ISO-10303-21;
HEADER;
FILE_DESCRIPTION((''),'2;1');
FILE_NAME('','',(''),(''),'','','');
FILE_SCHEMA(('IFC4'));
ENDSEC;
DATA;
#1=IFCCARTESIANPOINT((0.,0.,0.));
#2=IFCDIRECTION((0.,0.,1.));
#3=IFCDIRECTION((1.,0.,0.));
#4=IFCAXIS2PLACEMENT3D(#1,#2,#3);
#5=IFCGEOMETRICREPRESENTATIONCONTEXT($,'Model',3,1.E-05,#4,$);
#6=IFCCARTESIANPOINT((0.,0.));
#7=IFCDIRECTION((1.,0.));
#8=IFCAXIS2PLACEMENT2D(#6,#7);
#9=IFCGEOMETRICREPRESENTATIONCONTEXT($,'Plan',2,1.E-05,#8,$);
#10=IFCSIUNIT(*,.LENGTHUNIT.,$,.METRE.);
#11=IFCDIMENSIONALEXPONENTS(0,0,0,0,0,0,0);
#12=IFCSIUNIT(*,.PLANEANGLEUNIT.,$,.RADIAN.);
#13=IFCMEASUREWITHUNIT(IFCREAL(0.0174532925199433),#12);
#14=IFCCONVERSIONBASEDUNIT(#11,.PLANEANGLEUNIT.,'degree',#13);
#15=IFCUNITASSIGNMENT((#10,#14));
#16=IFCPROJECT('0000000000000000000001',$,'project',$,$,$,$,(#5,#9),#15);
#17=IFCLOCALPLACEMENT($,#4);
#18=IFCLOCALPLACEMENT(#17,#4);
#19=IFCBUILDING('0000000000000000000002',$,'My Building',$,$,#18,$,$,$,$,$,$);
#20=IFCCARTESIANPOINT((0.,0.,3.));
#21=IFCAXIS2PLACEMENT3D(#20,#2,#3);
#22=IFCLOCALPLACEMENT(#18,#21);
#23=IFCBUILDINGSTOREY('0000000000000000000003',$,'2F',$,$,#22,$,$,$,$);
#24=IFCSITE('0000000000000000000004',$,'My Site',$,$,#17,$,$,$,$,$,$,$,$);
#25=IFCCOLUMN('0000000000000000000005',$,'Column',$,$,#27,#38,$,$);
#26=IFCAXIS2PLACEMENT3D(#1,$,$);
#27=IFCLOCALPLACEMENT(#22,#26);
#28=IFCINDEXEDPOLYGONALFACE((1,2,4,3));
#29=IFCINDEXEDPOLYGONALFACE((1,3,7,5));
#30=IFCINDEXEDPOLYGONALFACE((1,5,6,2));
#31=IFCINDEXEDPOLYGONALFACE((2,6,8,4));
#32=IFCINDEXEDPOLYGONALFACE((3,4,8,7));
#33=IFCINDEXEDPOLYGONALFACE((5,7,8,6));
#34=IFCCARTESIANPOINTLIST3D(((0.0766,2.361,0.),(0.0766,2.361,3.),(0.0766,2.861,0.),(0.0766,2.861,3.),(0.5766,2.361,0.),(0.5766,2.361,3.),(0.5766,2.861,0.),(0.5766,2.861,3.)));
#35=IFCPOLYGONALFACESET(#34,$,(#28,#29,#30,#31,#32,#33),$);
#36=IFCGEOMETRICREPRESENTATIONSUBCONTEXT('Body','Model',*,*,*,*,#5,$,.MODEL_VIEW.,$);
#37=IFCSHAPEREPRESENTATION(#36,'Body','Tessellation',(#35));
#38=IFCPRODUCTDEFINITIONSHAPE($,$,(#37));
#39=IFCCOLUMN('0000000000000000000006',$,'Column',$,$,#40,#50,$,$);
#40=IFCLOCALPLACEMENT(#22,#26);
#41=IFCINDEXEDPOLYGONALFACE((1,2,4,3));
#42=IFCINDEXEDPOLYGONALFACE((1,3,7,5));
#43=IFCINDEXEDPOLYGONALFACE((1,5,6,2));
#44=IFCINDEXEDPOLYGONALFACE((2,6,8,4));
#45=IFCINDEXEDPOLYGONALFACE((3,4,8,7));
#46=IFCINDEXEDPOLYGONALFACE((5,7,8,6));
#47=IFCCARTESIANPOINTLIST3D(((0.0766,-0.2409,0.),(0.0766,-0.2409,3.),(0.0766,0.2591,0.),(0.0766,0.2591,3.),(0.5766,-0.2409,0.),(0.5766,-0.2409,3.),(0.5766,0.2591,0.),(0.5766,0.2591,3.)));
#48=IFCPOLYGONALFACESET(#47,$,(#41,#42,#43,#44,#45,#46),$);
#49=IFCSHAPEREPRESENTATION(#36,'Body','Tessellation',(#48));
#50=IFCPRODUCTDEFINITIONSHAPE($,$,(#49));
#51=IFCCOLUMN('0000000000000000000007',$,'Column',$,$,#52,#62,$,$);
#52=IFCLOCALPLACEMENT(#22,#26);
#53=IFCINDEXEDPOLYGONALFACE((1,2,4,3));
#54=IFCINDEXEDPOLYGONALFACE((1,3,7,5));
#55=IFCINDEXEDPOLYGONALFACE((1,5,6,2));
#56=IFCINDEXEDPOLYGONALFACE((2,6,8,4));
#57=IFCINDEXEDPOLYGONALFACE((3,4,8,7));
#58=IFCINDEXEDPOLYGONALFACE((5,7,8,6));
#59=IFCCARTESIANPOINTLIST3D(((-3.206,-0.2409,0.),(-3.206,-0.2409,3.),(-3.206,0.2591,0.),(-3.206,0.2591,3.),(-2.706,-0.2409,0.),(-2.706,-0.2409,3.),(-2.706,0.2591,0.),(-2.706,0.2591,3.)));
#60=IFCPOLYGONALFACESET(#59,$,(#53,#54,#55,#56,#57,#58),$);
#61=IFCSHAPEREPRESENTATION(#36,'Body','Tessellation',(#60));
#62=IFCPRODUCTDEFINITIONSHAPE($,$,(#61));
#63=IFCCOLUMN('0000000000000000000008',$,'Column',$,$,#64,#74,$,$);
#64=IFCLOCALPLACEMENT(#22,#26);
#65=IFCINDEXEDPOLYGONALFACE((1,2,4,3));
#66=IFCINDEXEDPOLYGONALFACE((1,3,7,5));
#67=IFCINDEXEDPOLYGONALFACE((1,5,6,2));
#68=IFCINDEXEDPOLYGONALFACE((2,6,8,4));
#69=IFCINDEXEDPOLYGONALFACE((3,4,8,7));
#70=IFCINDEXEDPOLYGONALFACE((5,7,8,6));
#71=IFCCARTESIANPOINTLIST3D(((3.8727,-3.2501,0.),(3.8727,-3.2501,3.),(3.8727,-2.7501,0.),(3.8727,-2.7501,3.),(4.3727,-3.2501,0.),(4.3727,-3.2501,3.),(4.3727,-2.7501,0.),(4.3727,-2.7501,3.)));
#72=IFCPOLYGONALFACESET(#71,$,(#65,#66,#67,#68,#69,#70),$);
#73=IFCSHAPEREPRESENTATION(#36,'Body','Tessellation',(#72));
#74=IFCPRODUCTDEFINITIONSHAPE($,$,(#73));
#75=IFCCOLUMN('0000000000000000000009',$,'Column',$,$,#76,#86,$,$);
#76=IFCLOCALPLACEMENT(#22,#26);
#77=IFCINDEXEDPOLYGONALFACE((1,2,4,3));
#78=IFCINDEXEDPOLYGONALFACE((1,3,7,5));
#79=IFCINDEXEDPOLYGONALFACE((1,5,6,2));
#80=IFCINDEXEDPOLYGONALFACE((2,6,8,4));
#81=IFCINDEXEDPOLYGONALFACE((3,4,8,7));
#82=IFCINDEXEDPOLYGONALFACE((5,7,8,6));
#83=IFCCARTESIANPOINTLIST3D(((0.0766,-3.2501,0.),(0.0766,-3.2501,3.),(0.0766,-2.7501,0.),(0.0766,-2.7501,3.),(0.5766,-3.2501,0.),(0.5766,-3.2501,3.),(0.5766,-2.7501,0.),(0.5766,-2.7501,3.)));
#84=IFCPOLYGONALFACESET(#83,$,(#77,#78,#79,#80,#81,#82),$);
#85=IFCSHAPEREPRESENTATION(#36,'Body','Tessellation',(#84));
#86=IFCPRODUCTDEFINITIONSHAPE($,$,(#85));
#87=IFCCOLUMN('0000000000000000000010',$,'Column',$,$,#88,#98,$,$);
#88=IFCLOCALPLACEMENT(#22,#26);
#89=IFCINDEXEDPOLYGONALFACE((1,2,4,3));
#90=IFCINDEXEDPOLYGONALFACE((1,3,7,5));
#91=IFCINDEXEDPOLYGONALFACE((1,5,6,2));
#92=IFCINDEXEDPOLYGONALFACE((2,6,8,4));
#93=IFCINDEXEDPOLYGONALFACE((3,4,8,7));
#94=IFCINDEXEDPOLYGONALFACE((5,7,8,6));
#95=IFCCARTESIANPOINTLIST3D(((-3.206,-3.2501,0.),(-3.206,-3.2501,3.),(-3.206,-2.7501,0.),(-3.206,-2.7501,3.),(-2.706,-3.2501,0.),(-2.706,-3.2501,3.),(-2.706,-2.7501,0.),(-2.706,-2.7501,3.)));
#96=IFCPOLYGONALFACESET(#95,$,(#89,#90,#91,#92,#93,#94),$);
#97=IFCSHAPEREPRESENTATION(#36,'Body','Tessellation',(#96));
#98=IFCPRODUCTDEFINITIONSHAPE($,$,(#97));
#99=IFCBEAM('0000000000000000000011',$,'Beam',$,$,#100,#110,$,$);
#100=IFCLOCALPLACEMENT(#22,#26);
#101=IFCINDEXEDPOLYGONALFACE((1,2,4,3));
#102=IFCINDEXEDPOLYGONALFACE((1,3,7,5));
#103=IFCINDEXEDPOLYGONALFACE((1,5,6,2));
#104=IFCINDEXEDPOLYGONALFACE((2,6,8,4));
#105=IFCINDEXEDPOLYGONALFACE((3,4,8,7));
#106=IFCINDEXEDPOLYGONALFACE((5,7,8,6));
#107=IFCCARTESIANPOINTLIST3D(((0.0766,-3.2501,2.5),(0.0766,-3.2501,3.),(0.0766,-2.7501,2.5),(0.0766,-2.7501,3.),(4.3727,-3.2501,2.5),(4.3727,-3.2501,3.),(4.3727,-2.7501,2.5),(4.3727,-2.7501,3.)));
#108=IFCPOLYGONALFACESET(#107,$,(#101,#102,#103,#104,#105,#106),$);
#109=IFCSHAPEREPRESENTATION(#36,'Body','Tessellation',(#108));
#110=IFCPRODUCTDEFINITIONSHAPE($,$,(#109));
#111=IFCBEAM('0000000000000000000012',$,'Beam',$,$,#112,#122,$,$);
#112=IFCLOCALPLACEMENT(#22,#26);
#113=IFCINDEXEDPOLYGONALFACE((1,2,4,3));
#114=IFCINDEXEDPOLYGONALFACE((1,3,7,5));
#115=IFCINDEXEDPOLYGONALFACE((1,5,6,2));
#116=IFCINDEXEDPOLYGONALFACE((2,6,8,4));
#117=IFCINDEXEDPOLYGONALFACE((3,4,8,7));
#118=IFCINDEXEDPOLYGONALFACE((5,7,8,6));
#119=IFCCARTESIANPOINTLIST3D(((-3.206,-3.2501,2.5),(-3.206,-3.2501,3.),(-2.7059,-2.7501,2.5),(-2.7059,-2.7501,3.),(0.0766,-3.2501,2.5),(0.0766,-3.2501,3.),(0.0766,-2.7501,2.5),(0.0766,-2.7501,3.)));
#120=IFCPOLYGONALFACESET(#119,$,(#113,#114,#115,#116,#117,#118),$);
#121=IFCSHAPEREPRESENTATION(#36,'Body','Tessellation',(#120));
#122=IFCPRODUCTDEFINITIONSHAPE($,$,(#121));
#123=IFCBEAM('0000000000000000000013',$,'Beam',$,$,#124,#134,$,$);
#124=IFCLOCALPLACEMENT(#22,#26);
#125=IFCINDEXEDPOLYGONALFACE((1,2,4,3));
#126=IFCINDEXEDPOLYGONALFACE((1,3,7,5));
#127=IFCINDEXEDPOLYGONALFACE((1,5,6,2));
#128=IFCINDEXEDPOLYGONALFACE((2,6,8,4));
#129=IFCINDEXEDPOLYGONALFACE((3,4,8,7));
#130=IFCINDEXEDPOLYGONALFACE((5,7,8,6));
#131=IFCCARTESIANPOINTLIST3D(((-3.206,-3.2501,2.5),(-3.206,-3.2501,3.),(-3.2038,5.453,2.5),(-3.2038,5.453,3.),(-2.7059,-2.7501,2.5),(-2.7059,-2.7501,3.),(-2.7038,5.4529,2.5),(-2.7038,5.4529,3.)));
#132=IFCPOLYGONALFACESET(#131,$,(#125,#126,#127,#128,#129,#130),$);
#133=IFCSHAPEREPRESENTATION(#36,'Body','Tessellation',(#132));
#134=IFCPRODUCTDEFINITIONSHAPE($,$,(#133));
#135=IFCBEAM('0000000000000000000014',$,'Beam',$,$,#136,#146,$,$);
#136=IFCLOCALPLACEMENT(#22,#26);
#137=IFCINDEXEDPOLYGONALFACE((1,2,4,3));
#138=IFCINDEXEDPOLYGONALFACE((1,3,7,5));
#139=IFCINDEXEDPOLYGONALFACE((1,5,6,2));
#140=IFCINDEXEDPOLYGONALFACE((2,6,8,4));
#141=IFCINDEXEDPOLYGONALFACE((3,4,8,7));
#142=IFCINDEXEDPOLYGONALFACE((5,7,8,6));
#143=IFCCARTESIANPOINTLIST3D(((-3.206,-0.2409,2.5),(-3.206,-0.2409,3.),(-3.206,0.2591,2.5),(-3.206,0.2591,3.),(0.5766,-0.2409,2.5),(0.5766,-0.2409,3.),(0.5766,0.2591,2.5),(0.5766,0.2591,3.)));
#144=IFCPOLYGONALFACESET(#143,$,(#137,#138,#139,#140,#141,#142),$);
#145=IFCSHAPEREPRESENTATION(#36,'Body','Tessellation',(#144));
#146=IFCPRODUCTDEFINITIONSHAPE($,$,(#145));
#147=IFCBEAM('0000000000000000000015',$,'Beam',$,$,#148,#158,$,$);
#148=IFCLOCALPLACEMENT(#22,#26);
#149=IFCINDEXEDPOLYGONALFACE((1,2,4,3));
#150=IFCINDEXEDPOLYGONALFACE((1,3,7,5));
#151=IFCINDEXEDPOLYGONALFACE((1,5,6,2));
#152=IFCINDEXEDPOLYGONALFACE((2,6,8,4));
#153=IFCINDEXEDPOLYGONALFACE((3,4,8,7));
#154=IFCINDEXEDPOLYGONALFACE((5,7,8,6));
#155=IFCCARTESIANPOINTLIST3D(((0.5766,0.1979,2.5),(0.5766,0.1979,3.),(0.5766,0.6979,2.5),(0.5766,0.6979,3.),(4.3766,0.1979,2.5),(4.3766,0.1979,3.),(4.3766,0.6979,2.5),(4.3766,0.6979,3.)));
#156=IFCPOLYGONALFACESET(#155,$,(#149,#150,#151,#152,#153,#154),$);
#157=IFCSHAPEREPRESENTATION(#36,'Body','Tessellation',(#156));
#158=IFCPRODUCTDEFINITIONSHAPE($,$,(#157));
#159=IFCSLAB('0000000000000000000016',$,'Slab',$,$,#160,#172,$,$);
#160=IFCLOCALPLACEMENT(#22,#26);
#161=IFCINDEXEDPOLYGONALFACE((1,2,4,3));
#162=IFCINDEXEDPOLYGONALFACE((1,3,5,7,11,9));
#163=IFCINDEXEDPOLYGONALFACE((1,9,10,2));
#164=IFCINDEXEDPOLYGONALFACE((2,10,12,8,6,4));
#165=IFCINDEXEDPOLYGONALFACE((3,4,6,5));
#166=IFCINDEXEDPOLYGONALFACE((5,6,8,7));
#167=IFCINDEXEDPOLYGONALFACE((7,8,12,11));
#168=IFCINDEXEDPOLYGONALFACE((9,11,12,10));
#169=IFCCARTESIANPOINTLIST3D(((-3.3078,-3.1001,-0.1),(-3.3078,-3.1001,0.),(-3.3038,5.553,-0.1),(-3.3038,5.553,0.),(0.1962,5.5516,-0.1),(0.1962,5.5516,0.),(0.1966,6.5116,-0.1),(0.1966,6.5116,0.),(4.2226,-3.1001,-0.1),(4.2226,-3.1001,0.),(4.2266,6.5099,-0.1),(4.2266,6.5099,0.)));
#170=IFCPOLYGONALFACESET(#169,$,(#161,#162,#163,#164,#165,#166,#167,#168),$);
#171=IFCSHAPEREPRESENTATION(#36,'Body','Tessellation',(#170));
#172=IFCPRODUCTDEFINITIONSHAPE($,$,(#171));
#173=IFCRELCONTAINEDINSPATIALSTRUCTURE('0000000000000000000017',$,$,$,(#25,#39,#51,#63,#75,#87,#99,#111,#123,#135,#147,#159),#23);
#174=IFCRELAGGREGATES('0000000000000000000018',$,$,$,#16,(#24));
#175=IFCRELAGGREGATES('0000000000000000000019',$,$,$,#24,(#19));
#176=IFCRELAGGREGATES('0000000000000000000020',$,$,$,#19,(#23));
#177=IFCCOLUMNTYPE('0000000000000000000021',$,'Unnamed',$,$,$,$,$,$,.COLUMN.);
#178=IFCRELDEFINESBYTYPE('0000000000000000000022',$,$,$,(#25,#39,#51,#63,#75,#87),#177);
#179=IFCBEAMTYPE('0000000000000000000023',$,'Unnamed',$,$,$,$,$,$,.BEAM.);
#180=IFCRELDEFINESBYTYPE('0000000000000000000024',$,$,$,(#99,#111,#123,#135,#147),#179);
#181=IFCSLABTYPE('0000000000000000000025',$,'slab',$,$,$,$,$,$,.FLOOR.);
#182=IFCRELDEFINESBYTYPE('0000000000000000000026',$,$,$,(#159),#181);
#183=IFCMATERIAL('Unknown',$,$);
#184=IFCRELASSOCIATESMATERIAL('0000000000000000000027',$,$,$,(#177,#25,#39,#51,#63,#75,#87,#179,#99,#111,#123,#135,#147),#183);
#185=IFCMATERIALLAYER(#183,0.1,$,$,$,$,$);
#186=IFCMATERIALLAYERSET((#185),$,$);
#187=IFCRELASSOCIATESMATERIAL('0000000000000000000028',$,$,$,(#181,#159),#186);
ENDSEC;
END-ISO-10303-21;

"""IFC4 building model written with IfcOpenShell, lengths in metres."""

from ifc_helpers import new_model, entity, si_unit, converted_unit, frame, origin_with_axes, origin_2d_with_axis, place, context, subcontext, project, spatial, indexed_curve, rectangle, outline, extrude, clip, halfspace, material, layer, layer_set, layer_usage, material_profile, profile_set, profile_usage, type_object, element, save


model = new_model("IFC4")

# Units and contexts
model_context = context("Model", 3, precision=1e-05, world=origin_with_axes())
plan_context = context("Plan", 2, precision=1e-05, world=origin_2d_with_axis())
body_context_1 = subcontext(model_context, "Body", "Model", "MODEL_VIEW")
ifc_project = project(units=[si_unit("LENGTHUNIT", "METRE"), converted_unit("PLANEANGLEUNIT", "degree", entity("IfcReal", 0.0174532925199433), si_unit("PLANEANGLEUNIT", "RADIAN"), dimensions=[0, 0, 0, 0, 0, 0, 0])], contexts=[model_context, plan_context])

# Site, building, storey
site_placement = place(None, origin_with_axes())
site = spatial("IfcSite", under=ifc_project, at=site_placement, Name="My Site")
building_placement = place(site_placement, origin_with_axes())
building = spatial("IfcBuilding", under=site, at=building_placement, Name="My Building")
storey_placement = place(building_placement, frame((0.0, 0.0, 3.0), z_axis=(0.0, 0.0, 1.0), x_axis=(1.0, 0.0, 0.0)))
storey = spatial("IfcBuildingStorey", under=building, at=storey_placement, Name="2F")

# Columns
ifc_material = material(Name="Unknown")
ifc_material_profile_1 = material_profile(ifc_material, rectangle(XDim=0.5, YDim=0.5))
ifc_profile_set_1 = profile_set([ifc_material_profile_1])
ifc_profile_usage_1 = profile_usage(ifc_profile_set_1, cardinal=7)
column_type = type_object("IfcColumnType", Name="Unnamed", PredefinedType="COLUMN", material=ifc_profile_set_1)
column_1_placement = place(storey_placement, frame((0.5766, 2.861, 0.0), z_axis=(0.0, 0.0, 1.0), x_axis=(1.0, 0.0, 0.0)))
element("IfcColumn", 1, at=column_1_placement, inside=storey, type_object=column_type, material=ifc_profile_usage_1, Name="Column", context=body_context_1, shape_type="SweptSolid", body=[
    extrude(rectangle(XDim=0.5, YDim=0.5), frame((-0.25, -0.25, 0.0), z_axis=(0.0, 0.0, 1.0), x_axis=(1.0, 0.0, 0.0)), (0.0, 0.0, 1.0), 3.0),
])
ifc_profile_usage_2 = profile_usage(ifc_profile_set_1, cardinal=9)
column_2_placement = place(storey_placement, frame((0.0766, 0.2591, 0.0), z_axis=(0.0, 0.0, 1.0), x_axis=(1.0, 0.0, 0.0)))
element("IfcColumn", 2, at=column_2_placement, inside=storey, type_object=column_type, material=ifc_profile_usage_2, Name="Column", context=body_context_1, shape_type="SweptSolid", body=[
    extrude(rectangle(XDim=0.5, YDim=0.5), frame((0.25, -0.25, 0.0), z_axis=(0.0, 0.0, 1.0), x_axis=(1.0, 0.0, 0.0)), (0.0, 0.0, 1.0), 3.0),
])
ifc_profile_usage_3 = profile_usage(ifc_profile_set_1, cardinal=9)
column_3_placement = place(storey_placement, frame((-3.206, 0.2591, 0.0), z_axis=(0.0, 0.0, 1.0), x_axis=(1.0, 0.0, 0.0)))
element("IfcColumn", 3, at=column_3_placement, inside=storey, type_object=column_type, material=ifc_profile_usage_3, Name="Column", context=body_context_1, shape_type="SweptSolid", body=[
    extrude(rectangle(XDim=0.5, YDim=0.5), frame((0.25, -0.25, 0.0), z_axis=(0.0, 0.0, 1.0), x_axis=(1.0, 0.0, 0.0)), (0.0, 0.0, 1.0), 3.0),
])
ifc_profile_usage_4 = profile_usage(ifc_profile_set_1, cardinal=5)
column_4_placement = place(storey_placement, frame((4.1227, -3.0001, 0.0), z_axis=(0.0, 0.0, 1.0), x_axis=(1.0, 0.0, 0.0)))
element("IfcColumn", 4, at=column_4_placement, inside=storey, type_object=column_type, material=ifc_profile_usage_4, Name="Column", context=body_context_1, shape_type="SweptSolid", body=[
    extrude(rectangle(XDim=0.5, YDim=0.5), origin_with_axes(), (0.0, 0.0, 1.0), 3.0),
])
ifc_profile_usage_5 = profile_usage(ifc_profile_set_1, cardinal=5)
column_5_placement = place(storey_placement, frame((0.3266, -3.0001, 0.0), z_axis=(0.0, 0.0, 1.0), x_axis=(1.0, 0.0, 0.0)))
element("IfcColumn", 5, at=column_5_placement, inside=storey, type_object=column_type, material=ifc_profile_usage_5, Name="Column", context=body_context_1, shape_type="SweptSolid", body=[
    extrude(rectangle(XDim=0.5, YDim=0.5), origin_with_axes(), (0.0, 0.0, 1.0), 3.0),
])
ifc_profile_usage_6 = profile_usage(ifc_profile_set_1, cardinal=5)
column_6_placement = place(storey_placement, frame((-2.956, -3.0001, 0.0), z_axis=(0.0, 0.0, 1.0), x_axis=(1.0, 0.0, 0.0)))
element("IfcColumn", 6, at=column_6_placement, inside=storey, type_object=column_type, material=ifc_profile_usage_6, Name="Column", context=body_context_1, shape_type="SweptSolid", body=[
    extrude(rectangle(XDim=0.5, YDim=0.5), origin_with_axes(), (0.0, 0.0, 1.0), 3.0),
])

# Beams
ifc_material_profile_2 = material_profile(ifc_material, rectangle(XDim=0.5, YDim=0.5))
ifc_profile_set_2 = profile_set([ifc_material_profile_2])
ifc_profile_usage_7 = profile_usage(ifc_profile_set_2, cardinal=7)
beam_type = type_object("IfcBeamType", Name="Unnamed", PredefinedType="BEAM", material=ifc_profile_set_2)
beam_1_placement = place(storey_placement, frame((4.3727, -3.2501, 3.0), z_axis=(-1.0, 0.0, 0.0), x_axis=(0.0, -1.0, 0.0)))
element("IfcBeam", 7, at=beam_1_placement, inside=storey, type_object=beam_type, material=ifc_profile_usage_7, Name="Beam", context=body_context_1, shape_type="SweptSolid", body=[
    extrude(rectangle(XDim=0.5, YDim=0.5), frame((-0.25, -0.25, 0.0), z_axis=(0.0, 0.0, 1.0), x_axis=(1.0, 0.0, 0.0)), (0.0, 0.0, 1.0), 4.2961),
])
ifc_profile_usage_8 = profile_usage(ifc_profile_set_2, cardinal=7)
beam_2_placement = place(storey_placement, frame((0.0766, -3.2501, 3.0), z_axis=(-1.0, 0.0, 0.0), x_axis=(0.0, -1.0, 0.0)))
element("IfcBeam", 8, at=beam_2_placement, inside=storey, type_object=beam_type, material=ifc_profile_usage_8, Name="Beam", context=body_context_1, shape_type="Clipping", body=[
    clip(extrude(rectangle(XDim=0.5, YDim=0.5), frame((-0.25, -0.25, 0.0), z_axis=(0.0, 0.0, 1.0), x_axis=(1.0, 0.0, 0.0)), (0.0, 0.0, 1.0), 3.7826), halfspace(frame((0.0, -6.0, 3.2826), z_axis=(-0.707196, 0.0, 0.707018), x_axis=(0.0, 1.0, 0.0)), False)),
])
ifc_profile_usage_9 = profile_usage(ifc_profile_set_2, cardinal=7)
beam_3_placement = place(storey_placement, frame((-3.2061, -3.7501, 3.0), z_axis=(0.000251, 1.0, 0.0), x_axis=(-1.0, 0.000251, 0.0)))
element("IfcBeam", 9, at=beam_3_placement, inside=storey, type_object=beam_type, material=ifc_profile_usage_9, Name="Beam", context=body_context_1, shape_type="Clipping", body=[
    clip(extrude(rectangle(XDim=0.5, YDim=0.5), frame((-0.25, -0.25, 0.0), z_axis=(0.0, 0.0, 1.0), x_axis=(1.0, 0.0, 0.0)), (0.0, 0.0, 1.0), 9.2031), halfspace(frame((0.0, -6.0, 0.5), z_axis=(-0.707196, 0.0, -0.707018), x_axis=(0.0, 1.0, 0.0)), False)),
])
ifc_profile_usage_10 = profile_usage(ifc_profile_set_2, cardinal=7)
beam_4_placement = place(storey_placement, frame((-3.206, 0.2591, 3.0), z_axis=(1.0, 0.0, 0.0), x_axis=(0.0, 1.0, 0.0)))
element("IfcBeam", 10, at=beam_4_placement, inside=storey, type_object=beam_type, material=ifc_profile_usage_10, Name="Beam", context=body_context_1, shape_type="SweptSolid", body=[
    extrude(rectangle(XDim=0.5, YDim=0.5), frame((-0.25, -0.25, 0.0), z_axis=(0.0, 0.0, 1.0), x_axis=(1.0, 0.0, 0.0)), (0.0, 0.0, 1.0), 3.7827),
])
ifc_profile_usage_11 = profile_usage(ifc_profile_set_2, cardinal=7)
beam_5_placement = place(storey_placement, frame((0.5766, 0.6979, 3.0), z_axis=(1.0, 0.000001, 0.0), x_axis=(-0.000001, 1.0, 0.0)))
element("IfcBeam", 11, at=beam_5_placement, inside=storey, type_object=beam_type, material=ifc_profile_usage_11, Name="Beam", context=body_context_1, shape_type="SweptSolid", body=[
    extrude(rectangle(XDim=0.5, YDim=0.5), frame((-0.25, -0.25, 0.0), z_axis=(0.0, 0.0, 1.0), x_axis=(1.0, 0.0, 0.0)), (0.0, 0.0, 1.0), 3.8),
])

# Slab
ifc_layer_1 = layer(ifc_material, 0.1)
ifc_layer_set_1 = layer_set([ifc_layer_1])
ifc_layer_usage_1 = layer_usage(ifc_layer_set_1, "AXIS3", "POSITIVE", -0.1)
slab_type = type_object("IfcSlabType", Name="slab", PredefinedType="FLOOR", material=ifc_layer_set_1)
slab_placement = place(storey_placement, frame((-3.3078, -3.1001, 0.0), z_axis=(0.0, 0.0, 1.0), x_axis=(1.0, 0.0, 0.0)))
element("IfcSlab", 12, at=slab_placement, inside=storey, type_object=slab_type, material=ifc_layer_usage_1, Name="Slab", context=body_context_1, shape_type="SweptSolid", body=[
    extrude(outline(indexed_curve([(0.0, 0.0), (7.5304, 0.0), (7.5344, 9.61), (3.5044, 9.6117), (3.504, 8.6517), (0.004, 8.6531), (0.0, 0.0)])), frame((0.0, 0.0, -0.1), z_axis=(0.0, 0.0, 1.0), x_axis=(1.0, 0.0, 0.0)), (0.0, 0.0, 1.0), 0.1),
])

save(model, "model.ifc")
